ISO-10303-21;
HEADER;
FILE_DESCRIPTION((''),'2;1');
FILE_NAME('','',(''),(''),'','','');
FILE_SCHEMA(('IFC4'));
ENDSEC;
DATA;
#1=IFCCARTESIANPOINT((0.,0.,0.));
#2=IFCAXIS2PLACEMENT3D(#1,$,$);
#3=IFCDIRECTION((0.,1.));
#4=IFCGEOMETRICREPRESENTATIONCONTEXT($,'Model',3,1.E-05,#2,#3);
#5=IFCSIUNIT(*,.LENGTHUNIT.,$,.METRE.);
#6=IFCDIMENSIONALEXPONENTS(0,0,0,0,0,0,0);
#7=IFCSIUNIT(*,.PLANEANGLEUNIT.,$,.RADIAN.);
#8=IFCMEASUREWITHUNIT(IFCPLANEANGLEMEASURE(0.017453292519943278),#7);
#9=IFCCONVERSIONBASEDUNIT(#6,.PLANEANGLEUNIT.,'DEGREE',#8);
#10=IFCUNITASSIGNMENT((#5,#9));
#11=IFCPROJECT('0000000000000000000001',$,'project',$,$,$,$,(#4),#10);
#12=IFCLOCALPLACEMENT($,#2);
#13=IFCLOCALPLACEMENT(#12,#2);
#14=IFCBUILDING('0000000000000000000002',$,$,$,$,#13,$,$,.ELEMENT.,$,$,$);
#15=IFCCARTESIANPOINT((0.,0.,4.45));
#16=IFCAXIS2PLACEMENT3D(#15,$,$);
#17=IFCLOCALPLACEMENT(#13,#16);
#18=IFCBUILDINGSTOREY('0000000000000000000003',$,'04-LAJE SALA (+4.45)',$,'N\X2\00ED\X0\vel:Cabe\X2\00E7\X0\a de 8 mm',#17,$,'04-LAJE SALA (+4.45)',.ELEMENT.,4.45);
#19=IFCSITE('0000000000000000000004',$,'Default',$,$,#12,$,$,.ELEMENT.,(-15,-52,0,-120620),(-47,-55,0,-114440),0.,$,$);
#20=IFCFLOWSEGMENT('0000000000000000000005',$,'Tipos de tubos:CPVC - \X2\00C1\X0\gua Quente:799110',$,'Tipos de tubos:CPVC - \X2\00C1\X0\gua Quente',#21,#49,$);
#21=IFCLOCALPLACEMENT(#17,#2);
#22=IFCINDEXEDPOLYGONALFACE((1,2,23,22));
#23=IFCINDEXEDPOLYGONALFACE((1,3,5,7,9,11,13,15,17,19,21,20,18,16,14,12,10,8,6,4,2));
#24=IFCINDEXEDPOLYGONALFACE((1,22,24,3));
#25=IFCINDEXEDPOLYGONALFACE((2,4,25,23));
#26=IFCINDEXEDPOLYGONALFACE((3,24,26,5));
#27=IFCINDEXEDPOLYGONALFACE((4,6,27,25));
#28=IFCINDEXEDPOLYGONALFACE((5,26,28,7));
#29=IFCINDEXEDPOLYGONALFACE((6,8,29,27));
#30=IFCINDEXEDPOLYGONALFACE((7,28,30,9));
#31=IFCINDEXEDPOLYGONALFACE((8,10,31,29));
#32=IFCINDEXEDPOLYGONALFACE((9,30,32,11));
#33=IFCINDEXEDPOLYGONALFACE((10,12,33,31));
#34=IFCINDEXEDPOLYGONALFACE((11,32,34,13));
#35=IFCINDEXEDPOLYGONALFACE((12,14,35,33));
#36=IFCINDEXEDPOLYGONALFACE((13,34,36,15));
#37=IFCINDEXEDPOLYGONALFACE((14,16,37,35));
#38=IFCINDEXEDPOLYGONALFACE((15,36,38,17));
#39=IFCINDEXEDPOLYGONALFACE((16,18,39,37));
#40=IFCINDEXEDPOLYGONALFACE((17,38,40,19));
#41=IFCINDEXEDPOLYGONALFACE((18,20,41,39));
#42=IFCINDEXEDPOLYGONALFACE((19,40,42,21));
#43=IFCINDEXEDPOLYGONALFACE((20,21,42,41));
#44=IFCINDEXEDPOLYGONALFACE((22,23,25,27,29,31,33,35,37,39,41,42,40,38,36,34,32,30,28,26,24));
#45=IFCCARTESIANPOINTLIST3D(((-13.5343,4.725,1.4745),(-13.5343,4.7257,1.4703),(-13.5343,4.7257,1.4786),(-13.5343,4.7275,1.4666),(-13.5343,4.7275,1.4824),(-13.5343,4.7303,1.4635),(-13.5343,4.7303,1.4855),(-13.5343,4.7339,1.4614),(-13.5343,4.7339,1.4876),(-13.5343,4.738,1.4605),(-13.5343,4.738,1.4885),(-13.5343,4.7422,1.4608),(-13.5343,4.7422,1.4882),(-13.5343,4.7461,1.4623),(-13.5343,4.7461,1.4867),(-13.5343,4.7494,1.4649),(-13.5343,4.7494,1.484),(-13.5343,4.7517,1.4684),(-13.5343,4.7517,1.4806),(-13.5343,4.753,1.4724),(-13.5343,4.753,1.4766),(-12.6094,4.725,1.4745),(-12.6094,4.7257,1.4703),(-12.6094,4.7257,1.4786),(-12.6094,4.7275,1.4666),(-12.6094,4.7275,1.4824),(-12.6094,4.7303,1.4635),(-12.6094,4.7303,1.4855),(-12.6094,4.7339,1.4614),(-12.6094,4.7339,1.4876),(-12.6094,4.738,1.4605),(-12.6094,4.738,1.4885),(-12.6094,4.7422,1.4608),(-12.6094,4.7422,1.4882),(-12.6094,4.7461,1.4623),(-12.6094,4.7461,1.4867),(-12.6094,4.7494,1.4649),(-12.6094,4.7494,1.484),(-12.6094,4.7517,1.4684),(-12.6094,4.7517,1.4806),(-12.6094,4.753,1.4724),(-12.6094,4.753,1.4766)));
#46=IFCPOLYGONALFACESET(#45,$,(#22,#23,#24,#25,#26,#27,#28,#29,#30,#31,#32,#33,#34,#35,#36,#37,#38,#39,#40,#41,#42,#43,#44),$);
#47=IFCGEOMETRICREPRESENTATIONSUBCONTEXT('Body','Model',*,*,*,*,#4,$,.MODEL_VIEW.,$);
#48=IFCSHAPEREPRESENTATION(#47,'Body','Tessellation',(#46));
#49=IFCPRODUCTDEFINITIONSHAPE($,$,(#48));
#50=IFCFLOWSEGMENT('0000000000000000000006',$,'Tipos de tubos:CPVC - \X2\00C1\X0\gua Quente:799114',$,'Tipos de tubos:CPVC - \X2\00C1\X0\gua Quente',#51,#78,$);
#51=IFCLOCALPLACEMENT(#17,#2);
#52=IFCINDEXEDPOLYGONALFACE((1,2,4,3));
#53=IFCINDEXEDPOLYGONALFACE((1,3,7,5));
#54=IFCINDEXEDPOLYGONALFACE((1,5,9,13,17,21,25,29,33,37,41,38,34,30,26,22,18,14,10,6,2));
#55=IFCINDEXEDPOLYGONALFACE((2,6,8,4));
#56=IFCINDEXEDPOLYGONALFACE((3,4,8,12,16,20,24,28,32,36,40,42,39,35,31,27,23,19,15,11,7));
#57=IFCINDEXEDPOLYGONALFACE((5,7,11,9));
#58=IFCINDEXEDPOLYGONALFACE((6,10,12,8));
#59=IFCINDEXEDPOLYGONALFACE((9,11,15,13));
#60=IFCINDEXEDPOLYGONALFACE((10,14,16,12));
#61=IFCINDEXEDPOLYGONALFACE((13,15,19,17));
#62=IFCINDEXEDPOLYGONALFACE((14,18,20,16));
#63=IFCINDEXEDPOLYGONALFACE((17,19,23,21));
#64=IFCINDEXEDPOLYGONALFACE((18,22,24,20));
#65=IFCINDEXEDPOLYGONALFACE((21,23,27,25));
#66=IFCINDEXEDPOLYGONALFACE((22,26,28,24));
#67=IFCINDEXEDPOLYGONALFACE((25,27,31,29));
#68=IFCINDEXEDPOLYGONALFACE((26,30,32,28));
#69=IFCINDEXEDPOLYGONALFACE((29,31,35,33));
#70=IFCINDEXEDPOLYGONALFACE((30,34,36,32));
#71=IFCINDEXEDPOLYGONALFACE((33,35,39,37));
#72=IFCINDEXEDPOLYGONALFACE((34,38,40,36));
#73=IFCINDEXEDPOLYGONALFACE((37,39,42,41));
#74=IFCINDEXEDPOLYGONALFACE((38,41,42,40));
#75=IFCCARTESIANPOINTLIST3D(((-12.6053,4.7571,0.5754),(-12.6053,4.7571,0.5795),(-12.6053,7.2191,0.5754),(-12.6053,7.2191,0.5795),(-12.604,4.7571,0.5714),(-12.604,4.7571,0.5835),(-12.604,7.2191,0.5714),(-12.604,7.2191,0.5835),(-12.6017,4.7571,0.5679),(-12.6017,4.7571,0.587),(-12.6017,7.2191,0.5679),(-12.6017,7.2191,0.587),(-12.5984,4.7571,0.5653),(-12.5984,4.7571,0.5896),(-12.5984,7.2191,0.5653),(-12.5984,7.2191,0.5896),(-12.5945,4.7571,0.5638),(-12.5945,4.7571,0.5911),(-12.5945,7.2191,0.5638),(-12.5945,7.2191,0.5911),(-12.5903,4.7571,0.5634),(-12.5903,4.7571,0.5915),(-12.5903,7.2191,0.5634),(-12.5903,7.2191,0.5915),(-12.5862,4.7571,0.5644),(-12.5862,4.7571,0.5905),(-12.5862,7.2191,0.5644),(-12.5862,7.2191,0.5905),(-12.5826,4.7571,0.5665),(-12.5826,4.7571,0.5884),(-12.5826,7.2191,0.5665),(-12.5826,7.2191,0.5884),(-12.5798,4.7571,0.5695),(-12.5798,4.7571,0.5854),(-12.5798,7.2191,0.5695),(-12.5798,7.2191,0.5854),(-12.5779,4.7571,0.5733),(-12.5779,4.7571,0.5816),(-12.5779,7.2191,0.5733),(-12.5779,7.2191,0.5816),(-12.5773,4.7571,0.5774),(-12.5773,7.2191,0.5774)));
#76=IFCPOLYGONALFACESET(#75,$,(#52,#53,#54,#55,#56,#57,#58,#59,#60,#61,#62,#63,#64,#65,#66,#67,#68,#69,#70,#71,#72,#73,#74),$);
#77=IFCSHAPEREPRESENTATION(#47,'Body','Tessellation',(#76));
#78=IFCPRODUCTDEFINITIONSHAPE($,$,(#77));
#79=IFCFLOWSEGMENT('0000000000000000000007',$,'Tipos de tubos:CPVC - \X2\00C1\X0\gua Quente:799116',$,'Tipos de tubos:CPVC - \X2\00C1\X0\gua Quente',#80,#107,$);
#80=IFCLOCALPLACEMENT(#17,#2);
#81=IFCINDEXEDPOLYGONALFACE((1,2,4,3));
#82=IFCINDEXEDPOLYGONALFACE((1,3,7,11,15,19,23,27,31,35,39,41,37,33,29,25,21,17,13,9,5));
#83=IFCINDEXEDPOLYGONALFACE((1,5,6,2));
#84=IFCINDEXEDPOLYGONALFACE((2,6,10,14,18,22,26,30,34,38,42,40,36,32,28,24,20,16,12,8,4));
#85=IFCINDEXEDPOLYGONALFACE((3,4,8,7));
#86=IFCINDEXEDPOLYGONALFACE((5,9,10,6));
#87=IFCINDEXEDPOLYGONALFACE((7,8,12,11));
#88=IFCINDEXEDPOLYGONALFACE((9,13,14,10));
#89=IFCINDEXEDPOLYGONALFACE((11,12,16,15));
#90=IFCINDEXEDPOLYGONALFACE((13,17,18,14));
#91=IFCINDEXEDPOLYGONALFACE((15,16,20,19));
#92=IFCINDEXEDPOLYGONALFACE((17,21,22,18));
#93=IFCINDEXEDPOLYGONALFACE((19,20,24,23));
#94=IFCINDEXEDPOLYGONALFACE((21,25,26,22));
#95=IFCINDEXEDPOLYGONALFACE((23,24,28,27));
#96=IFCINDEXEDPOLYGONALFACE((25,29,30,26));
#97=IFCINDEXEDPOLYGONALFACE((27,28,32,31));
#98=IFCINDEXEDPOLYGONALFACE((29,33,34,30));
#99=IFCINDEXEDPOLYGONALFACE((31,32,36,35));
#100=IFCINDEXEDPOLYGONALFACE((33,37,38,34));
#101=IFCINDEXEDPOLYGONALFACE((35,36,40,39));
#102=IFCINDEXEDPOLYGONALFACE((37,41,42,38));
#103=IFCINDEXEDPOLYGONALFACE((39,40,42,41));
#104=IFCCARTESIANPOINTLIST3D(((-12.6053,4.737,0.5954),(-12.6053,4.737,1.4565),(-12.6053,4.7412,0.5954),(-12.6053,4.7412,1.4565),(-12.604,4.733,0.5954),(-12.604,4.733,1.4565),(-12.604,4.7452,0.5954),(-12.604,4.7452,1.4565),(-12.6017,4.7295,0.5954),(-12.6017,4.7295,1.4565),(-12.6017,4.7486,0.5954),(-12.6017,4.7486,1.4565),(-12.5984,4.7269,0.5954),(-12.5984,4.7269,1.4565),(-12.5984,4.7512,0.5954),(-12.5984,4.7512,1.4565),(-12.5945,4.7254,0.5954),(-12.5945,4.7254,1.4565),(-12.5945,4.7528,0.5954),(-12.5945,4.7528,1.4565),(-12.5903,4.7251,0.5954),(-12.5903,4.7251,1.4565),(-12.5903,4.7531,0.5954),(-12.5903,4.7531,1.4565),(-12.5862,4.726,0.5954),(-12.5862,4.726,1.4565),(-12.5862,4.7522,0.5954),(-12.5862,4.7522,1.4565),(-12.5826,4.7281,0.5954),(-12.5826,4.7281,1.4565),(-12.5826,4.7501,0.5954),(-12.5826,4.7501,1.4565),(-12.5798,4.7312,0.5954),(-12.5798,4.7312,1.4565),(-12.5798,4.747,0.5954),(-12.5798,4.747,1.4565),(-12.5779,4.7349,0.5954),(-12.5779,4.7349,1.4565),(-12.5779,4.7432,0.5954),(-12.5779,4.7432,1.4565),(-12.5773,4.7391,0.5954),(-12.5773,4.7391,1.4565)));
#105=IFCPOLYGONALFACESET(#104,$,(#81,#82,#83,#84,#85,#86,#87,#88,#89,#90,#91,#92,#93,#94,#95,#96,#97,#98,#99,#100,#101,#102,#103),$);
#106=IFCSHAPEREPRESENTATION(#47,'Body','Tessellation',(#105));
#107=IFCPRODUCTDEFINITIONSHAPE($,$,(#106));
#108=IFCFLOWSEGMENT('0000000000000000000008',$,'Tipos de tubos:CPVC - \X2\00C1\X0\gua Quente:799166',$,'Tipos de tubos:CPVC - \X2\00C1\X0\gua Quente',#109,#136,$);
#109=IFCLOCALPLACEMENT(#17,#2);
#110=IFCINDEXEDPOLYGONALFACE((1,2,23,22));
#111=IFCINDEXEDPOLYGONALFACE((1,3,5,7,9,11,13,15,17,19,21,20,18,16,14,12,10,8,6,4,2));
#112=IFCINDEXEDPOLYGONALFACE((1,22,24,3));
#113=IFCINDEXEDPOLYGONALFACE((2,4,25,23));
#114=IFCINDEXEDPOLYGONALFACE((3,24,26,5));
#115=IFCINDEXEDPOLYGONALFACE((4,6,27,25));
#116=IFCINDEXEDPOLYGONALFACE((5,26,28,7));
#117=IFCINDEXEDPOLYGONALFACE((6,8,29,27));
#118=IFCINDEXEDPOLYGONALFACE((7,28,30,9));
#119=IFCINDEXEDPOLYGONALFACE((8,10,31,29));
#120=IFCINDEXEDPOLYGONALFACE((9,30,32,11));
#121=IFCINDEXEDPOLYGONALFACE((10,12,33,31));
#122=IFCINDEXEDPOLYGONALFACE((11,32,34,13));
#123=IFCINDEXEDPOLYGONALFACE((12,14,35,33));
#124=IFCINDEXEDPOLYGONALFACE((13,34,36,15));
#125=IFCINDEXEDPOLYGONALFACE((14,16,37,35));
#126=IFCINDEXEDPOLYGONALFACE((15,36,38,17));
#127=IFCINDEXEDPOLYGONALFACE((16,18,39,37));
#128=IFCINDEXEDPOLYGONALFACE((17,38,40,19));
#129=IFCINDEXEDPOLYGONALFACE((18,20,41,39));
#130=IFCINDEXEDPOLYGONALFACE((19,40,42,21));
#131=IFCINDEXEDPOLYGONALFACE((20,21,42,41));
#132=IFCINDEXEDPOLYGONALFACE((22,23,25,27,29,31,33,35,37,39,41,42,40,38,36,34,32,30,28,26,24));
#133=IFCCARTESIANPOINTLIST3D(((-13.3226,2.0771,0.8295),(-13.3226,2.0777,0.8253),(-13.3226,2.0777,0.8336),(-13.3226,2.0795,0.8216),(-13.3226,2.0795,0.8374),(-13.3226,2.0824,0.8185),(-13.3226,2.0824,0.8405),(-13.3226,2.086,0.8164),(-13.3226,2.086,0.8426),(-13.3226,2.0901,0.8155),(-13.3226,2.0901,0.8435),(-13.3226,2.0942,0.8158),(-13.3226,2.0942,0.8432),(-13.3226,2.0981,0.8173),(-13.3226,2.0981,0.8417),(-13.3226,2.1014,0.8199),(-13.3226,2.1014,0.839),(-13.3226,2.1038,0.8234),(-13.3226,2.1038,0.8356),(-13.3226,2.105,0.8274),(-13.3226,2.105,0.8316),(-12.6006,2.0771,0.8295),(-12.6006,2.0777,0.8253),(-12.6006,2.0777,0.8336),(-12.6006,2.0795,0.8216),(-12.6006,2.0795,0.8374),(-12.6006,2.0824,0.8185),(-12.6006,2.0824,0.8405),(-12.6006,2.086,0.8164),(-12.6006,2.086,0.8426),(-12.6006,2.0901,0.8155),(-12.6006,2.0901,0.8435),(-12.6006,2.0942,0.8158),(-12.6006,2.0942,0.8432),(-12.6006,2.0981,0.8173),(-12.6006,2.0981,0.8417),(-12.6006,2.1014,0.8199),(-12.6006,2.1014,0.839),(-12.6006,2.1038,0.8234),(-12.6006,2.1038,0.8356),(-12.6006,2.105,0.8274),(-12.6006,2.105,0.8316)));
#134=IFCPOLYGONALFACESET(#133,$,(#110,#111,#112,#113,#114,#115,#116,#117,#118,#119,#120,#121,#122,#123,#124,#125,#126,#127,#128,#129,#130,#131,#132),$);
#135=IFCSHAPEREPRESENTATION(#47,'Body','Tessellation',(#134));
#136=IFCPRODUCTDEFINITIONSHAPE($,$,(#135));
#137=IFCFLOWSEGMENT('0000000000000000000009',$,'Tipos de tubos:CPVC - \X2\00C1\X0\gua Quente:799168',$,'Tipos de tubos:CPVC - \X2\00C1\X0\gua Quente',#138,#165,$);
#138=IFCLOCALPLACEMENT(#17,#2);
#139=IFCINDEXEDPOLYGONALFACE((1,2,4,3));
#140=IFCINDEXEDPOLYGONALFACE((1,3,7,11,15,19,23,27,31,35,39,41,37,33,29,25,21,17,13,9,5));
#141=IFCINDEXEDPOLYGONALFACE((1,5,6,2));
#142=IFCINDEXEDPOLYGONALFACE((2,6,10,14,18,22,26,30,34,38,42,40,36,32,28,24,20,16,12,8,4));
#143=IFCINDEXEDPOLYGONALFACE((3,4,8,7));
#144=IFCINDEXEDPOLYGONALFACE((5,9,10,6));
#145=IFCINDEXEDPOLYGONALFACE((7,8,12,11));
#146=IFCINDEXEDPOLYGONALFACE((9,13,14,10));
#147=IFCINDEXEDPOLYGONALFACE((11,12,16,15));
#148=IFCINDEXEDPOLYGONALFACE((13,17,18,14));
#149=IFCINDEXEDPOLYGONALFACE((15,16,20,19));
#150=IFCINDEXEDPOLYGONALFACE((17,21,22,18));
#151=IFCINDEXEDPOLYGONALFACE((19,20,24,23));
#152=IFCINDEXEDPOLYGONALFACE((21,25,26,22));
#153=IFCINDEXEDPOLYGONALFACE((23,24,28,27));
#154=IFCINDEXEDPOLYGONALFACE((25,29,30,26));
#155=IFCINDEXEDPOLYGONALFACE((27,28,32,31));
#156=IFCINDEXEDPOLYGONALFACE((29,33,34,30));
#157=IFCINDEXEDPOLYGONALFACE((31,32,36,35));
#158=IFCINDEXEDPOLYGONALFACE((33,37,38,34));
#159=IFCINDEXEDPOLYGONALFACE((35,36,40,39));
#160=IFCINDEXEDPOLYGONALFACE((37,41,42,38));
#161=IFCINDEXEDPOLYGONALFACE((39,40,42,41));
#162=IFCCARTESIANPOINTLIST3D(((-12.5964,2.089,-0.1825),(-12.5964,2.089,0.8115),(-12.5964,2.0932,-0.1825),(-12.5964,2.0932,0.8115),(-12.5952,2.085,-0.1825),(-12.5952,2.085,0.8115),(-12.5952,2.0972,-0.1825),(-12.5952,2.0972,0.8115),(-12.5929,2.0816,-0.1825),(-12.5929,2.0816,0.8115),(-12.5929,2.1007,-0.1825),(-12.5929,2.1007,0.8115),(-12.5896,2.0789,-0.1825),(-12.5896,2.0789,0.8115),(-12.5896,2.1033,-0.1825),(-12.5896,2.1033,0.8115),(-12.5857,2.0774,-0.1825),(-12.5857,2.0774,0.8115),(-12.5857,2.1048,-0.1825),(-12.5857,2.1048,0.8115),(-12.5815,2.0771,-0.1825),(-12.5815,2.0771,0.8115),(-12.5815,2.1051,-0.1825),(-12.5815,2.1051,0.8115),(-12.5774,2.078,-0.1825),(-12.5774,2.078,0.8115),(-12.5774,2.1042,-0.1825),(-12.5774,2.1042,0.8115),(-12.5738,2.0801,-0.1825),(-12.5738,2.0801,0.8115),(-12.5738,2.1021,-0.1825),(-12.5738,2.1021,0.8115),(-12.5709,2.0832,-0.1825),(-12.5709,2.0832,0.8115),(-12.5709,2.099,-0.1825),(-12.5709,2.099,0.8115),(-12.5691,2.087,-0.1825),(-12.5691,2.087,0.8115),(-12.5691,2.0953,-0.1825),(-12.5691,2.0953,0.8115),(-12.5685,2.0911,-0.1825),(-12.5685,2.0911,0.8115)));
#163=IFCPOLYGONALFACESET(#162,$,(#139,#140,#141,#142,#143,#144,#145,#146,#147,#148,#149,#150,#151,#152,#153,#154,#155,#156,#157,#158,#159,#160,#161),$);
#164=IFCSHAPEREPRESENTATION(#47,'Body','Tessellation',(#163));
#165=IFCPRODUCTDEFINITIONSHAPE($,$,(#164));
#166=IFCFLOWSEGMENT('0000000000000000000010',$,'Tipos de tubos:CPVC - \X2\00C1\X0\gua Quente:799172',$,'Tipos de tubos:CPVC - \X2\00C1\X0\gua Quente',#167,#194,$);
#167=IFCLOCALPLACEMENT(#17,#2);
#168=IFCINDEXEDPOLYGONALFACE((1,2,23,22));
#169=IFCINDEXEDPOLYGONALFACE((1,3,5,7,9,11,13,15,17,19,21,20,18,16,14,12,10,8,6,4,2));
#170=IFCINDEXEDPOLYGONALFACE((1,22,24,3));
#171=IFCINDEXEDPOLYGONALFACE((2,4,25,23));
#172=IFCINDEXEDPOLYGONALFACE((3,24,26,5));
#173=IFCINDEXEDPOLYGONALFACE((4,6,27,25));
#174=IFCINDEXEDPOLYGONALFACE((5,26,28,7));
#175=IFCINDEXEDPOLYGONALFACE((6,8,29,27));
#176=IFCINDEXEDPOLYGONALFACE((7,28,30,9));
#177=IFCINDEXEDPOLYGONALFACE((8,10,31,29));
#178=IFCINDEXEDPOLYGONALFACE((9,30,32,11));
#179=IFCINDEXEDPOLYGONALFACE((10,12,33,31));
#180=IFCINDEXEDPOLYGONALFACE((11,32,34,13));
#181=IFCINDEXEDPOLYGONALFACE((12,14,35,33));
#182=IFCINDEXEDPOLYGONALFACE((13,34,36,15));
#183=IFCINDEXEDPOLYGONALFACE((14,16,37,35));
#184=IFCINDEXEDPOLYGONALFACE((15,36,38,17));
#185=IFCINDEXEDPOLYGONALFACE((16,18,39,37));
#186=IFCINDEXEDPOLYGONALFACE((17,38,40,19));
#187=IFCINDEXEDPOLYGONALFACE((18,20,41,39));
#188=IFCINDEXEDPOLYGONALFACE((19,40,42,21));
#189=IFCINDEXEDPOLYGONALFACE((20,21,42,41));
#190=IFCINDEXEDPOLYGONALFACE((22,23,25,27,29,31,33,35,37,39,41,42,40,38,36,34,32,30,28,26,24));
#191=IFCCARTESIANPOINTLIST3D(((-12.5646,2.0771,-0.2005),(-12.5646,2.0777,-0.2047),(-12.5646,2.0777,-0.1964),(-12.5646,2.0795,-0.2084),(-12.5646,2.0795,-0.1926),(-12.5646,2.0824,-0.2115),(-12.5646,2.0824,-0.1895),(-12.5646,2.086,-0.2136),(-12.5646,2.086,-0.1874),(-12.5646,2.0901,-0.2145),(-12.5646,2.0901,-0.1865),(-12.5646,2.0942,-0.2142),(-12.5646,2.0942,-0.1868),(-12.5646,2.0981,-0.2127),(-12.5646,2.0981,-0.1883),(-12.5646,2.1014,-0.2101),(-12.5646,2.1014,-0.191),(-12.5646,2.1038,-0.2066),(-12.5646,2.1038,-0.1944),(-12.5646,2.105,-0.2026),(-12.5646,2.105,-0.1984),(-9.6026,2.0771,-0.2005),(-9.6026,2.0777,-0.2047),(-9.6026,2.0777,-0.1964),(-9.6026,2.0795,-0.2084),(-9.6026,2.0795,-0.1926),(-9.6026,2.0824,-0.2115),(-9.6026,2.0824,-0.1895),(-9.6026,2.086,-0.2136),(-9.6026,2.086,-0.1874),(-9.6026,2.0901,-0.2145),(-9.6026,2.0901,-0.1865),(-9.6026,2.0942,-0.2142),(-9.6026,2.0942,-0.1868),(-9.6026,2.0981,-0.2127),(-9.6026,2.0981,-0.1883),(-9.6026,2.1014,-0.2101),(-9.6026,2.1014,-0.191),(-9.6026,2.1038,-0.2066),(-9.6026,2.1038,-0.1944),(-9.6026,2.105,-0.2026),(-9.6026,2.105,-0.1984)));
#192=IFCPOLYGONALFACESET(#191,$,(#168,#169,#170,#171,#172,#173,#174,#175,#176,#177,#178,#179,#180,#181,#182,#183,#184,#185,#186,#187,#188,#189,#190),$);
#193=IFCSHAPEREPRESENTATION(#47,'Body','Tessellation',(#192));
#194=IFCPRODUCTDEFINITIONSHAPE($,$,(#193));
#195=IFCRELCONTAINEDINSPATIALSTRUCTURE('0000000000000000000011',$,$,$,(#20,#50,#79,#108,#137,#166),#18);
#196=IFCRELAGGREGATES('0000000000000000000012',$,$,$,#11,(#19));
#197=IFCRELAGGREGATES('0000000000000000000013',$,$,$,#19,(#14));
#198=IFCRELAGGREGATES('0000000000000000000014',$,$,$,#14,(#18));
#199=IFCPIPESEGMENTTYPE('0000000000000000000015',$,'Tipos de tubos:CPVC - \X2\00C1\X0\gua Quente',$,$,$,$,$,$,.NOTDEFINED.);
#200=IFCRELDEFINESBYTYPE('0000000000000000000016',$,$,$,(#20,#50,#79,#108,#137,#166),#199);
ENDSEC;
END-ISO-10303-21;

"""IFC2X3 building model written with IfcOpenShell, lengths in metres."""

from ifc_helpers import new_model, entity, si_unit, converted_unit, direction, frame, frame_2d, origin, origin_2d_with_axis, place, context, subcontext, project, spatial, circle, extrude, type_object, element, save


model = new_model("IFC2X3")

# Units and contexts
model_context = context("Model", 3, precision=1e-05, world=origin(), true_north=direction((0.0, 1.0)))
body_context = subcontext(model_context, "Body", "Model", "MODEL_VIEW")
ifc_project = project(units=[si_unit("LENGTHUNIT", "METRE"), converted_unit("PLANEANGLEUNIT", "DEGREE", entity("IfcPlaneAngleMeasure", 0.017453292519943278), si_unit("PLANEANGLEUNIT", "RADIAN"), dimensions=[0, 0, 0, 0, 0, 0, 0])], contexts=[model_context])

# Site, building, storey
site_placement = place(None, origin())
site = spatial("IfcSite", under=ifc_project, at=site_placement, Name="Default", CompositionType="ELEMENT", RefLatitude=(-15, -52, 0, -120620), RefLongitude=(-47, -55, 0, -114440), RefElevation=0.0)
building_placement = place(site_placement, origin())
building = spatial("IfcBuilding", under=site, at=building_placement, CompositionType="ELEMENT")
storey_placement = place(building_placement, frame((0.0, 0.0, 4.45)))
storey = spatial("IfcBuildingStorey", under=building, at=storey_placement, Name="04-LAJE SALA (+4.45)", ObjectType="Nível:Cabeça de 8 mm", LongName="04-LAJE SALA (+4.45)", CompositionType="ELEMENT", Elevation=4.45)

# Flow segments
pipe_segment_type_1 = type_object("IfcPipeSegmentType", Name="Tipos de tubos:CPVC - Água Quente", PredefinedType="NOTDEFINED")
flow_segment_1_placement = place(storey_placement, origin())
element("IfcFlowSegment", 1, at=flow_segment_1_placement, inside=storey, type_object=pipe_segment_type_1, Name="Tipos de tubos:CPVC - Água Quente:799110", ObjectType="Tipos de tubos:CPVC - Água Quente", context=body_context, shape_type="SweptSolid", body=[
    extrude(circle(Radius=0.0141, at=frame_2d((0.0, 0.0), x_axis=(1.0, 0.0))), frame((-13.5343, 4.7391, 1.4745), z_axis=(1.0, 0.0, 0.0), x_axis=(0.0, -1.0, 0.0)), (0.0, 0.0, 1.0), 0.9249),
])
flow_segment_2_placement = place(storey_placement, origin())
element("IfcFlowSegment", 2, at=flow_segment_2_placement, inside=storey, type_object=pipe_segment_type_1, Name="Tipos de tubos:CPVC - Água Quente:799114", ObjectType="Tipos de tubos:CPVC - Água Quente", context=body_context, shape_type="SweptSolid", body=[
    extrude(circle(Radius=0.0141, at=origin_2d_with_axis()), frame((-12.5914, 4.7571, 0.5774), z_axis=(0.0, 1.0, 0.0), x_axis=(1.0, 0.0, 0.0)), (0.0, 0.0, 1.0), 2.462),
])
flow_segment_3_placement = place(storey_placement, origin())
element("IfcFlowSegment", 3, at=flow_segment_3_placement, inside=storey, type_object=pipe_segment_type_1, Name="Tipos de tubos:CPVC - Água Quente:799116", ObjectType="Tipos de tubos:CPVC - Água Quente", context=body_context, shape_type="SweptSolid", body=[
    extrude(circle(Radius=0.0141, at=origin_2d_with_axis()), frame((-12.5914, 4.7391, 0.5954)), (0.0, 0.0, 1.0), 0.861),
])
flow_segment_4_placement = place(storey_placement, origin())
element("IfcFlowSegment", 4, at=flow_segment_4_placement, inside=storey, type_object=pipe_segment_type_1, Name="Tipos de tubos:CPVC - Água Quente:799166", ObjectType="Tipos de tubos:CPVC - Água Quente", context=body_context, shape_type="SweptSolid", body=[
    extrude(circle(Radius=0.0141, at=frame_2d((0.0, 0.0), x_axis=(1.0, 0.0))), frame((-13.3226, 2.0911, 0.8295), z_axis=(1.0, 0.0, 0.0), x_axis=(0.0, -1.0, 0.0)), (0.0, 0.0, 1.0), 0.722),
])
flow_segment_5_placement = place(storey_placement, origin())
element("IfcFlowSegment", 5, at=flow_segment_5_placement, inside=storey, type_object=pipe_segment_type_1, Name="Tipos de tubos:CPVC - Água Quente:799168", ObjectType="Tipos de tubos:CPVC - Água Quente", context=body_context, shape_type="SweptSolid", body=[
    extrude(circle(Radius=0.0141, at=origin_2d_with_axis()), frame((-12.5826, 2.0911, -0.1825)), (0.0, 0.0, 1.0), 0.994),
])
flow_segment_6_placement = place(storey_placement, origin())
element("IfcFlowSegment", 6, at=flow_segment_6_placement, inside=storey, type_object=pipe_segment_type_1, Name="Tipos de tubos:CPVC - Água Quente:799172", ObjectType="Tipos de tubos:CPVC - Água Quente", context=body_context, shape_type="SweptSolid", body=[
    extrude(circle(Radius=0.0141, at=origin_2d_with_axis()), frame((-12.5646, 2.0911, -0.2005), z_axis=(1.0, 0.0, 0.0), x_axis=(0.0, -1.0, 0.0)), (0.0, 0.0, 1.0), 2.962),
])

save(model, "model.ifc")
